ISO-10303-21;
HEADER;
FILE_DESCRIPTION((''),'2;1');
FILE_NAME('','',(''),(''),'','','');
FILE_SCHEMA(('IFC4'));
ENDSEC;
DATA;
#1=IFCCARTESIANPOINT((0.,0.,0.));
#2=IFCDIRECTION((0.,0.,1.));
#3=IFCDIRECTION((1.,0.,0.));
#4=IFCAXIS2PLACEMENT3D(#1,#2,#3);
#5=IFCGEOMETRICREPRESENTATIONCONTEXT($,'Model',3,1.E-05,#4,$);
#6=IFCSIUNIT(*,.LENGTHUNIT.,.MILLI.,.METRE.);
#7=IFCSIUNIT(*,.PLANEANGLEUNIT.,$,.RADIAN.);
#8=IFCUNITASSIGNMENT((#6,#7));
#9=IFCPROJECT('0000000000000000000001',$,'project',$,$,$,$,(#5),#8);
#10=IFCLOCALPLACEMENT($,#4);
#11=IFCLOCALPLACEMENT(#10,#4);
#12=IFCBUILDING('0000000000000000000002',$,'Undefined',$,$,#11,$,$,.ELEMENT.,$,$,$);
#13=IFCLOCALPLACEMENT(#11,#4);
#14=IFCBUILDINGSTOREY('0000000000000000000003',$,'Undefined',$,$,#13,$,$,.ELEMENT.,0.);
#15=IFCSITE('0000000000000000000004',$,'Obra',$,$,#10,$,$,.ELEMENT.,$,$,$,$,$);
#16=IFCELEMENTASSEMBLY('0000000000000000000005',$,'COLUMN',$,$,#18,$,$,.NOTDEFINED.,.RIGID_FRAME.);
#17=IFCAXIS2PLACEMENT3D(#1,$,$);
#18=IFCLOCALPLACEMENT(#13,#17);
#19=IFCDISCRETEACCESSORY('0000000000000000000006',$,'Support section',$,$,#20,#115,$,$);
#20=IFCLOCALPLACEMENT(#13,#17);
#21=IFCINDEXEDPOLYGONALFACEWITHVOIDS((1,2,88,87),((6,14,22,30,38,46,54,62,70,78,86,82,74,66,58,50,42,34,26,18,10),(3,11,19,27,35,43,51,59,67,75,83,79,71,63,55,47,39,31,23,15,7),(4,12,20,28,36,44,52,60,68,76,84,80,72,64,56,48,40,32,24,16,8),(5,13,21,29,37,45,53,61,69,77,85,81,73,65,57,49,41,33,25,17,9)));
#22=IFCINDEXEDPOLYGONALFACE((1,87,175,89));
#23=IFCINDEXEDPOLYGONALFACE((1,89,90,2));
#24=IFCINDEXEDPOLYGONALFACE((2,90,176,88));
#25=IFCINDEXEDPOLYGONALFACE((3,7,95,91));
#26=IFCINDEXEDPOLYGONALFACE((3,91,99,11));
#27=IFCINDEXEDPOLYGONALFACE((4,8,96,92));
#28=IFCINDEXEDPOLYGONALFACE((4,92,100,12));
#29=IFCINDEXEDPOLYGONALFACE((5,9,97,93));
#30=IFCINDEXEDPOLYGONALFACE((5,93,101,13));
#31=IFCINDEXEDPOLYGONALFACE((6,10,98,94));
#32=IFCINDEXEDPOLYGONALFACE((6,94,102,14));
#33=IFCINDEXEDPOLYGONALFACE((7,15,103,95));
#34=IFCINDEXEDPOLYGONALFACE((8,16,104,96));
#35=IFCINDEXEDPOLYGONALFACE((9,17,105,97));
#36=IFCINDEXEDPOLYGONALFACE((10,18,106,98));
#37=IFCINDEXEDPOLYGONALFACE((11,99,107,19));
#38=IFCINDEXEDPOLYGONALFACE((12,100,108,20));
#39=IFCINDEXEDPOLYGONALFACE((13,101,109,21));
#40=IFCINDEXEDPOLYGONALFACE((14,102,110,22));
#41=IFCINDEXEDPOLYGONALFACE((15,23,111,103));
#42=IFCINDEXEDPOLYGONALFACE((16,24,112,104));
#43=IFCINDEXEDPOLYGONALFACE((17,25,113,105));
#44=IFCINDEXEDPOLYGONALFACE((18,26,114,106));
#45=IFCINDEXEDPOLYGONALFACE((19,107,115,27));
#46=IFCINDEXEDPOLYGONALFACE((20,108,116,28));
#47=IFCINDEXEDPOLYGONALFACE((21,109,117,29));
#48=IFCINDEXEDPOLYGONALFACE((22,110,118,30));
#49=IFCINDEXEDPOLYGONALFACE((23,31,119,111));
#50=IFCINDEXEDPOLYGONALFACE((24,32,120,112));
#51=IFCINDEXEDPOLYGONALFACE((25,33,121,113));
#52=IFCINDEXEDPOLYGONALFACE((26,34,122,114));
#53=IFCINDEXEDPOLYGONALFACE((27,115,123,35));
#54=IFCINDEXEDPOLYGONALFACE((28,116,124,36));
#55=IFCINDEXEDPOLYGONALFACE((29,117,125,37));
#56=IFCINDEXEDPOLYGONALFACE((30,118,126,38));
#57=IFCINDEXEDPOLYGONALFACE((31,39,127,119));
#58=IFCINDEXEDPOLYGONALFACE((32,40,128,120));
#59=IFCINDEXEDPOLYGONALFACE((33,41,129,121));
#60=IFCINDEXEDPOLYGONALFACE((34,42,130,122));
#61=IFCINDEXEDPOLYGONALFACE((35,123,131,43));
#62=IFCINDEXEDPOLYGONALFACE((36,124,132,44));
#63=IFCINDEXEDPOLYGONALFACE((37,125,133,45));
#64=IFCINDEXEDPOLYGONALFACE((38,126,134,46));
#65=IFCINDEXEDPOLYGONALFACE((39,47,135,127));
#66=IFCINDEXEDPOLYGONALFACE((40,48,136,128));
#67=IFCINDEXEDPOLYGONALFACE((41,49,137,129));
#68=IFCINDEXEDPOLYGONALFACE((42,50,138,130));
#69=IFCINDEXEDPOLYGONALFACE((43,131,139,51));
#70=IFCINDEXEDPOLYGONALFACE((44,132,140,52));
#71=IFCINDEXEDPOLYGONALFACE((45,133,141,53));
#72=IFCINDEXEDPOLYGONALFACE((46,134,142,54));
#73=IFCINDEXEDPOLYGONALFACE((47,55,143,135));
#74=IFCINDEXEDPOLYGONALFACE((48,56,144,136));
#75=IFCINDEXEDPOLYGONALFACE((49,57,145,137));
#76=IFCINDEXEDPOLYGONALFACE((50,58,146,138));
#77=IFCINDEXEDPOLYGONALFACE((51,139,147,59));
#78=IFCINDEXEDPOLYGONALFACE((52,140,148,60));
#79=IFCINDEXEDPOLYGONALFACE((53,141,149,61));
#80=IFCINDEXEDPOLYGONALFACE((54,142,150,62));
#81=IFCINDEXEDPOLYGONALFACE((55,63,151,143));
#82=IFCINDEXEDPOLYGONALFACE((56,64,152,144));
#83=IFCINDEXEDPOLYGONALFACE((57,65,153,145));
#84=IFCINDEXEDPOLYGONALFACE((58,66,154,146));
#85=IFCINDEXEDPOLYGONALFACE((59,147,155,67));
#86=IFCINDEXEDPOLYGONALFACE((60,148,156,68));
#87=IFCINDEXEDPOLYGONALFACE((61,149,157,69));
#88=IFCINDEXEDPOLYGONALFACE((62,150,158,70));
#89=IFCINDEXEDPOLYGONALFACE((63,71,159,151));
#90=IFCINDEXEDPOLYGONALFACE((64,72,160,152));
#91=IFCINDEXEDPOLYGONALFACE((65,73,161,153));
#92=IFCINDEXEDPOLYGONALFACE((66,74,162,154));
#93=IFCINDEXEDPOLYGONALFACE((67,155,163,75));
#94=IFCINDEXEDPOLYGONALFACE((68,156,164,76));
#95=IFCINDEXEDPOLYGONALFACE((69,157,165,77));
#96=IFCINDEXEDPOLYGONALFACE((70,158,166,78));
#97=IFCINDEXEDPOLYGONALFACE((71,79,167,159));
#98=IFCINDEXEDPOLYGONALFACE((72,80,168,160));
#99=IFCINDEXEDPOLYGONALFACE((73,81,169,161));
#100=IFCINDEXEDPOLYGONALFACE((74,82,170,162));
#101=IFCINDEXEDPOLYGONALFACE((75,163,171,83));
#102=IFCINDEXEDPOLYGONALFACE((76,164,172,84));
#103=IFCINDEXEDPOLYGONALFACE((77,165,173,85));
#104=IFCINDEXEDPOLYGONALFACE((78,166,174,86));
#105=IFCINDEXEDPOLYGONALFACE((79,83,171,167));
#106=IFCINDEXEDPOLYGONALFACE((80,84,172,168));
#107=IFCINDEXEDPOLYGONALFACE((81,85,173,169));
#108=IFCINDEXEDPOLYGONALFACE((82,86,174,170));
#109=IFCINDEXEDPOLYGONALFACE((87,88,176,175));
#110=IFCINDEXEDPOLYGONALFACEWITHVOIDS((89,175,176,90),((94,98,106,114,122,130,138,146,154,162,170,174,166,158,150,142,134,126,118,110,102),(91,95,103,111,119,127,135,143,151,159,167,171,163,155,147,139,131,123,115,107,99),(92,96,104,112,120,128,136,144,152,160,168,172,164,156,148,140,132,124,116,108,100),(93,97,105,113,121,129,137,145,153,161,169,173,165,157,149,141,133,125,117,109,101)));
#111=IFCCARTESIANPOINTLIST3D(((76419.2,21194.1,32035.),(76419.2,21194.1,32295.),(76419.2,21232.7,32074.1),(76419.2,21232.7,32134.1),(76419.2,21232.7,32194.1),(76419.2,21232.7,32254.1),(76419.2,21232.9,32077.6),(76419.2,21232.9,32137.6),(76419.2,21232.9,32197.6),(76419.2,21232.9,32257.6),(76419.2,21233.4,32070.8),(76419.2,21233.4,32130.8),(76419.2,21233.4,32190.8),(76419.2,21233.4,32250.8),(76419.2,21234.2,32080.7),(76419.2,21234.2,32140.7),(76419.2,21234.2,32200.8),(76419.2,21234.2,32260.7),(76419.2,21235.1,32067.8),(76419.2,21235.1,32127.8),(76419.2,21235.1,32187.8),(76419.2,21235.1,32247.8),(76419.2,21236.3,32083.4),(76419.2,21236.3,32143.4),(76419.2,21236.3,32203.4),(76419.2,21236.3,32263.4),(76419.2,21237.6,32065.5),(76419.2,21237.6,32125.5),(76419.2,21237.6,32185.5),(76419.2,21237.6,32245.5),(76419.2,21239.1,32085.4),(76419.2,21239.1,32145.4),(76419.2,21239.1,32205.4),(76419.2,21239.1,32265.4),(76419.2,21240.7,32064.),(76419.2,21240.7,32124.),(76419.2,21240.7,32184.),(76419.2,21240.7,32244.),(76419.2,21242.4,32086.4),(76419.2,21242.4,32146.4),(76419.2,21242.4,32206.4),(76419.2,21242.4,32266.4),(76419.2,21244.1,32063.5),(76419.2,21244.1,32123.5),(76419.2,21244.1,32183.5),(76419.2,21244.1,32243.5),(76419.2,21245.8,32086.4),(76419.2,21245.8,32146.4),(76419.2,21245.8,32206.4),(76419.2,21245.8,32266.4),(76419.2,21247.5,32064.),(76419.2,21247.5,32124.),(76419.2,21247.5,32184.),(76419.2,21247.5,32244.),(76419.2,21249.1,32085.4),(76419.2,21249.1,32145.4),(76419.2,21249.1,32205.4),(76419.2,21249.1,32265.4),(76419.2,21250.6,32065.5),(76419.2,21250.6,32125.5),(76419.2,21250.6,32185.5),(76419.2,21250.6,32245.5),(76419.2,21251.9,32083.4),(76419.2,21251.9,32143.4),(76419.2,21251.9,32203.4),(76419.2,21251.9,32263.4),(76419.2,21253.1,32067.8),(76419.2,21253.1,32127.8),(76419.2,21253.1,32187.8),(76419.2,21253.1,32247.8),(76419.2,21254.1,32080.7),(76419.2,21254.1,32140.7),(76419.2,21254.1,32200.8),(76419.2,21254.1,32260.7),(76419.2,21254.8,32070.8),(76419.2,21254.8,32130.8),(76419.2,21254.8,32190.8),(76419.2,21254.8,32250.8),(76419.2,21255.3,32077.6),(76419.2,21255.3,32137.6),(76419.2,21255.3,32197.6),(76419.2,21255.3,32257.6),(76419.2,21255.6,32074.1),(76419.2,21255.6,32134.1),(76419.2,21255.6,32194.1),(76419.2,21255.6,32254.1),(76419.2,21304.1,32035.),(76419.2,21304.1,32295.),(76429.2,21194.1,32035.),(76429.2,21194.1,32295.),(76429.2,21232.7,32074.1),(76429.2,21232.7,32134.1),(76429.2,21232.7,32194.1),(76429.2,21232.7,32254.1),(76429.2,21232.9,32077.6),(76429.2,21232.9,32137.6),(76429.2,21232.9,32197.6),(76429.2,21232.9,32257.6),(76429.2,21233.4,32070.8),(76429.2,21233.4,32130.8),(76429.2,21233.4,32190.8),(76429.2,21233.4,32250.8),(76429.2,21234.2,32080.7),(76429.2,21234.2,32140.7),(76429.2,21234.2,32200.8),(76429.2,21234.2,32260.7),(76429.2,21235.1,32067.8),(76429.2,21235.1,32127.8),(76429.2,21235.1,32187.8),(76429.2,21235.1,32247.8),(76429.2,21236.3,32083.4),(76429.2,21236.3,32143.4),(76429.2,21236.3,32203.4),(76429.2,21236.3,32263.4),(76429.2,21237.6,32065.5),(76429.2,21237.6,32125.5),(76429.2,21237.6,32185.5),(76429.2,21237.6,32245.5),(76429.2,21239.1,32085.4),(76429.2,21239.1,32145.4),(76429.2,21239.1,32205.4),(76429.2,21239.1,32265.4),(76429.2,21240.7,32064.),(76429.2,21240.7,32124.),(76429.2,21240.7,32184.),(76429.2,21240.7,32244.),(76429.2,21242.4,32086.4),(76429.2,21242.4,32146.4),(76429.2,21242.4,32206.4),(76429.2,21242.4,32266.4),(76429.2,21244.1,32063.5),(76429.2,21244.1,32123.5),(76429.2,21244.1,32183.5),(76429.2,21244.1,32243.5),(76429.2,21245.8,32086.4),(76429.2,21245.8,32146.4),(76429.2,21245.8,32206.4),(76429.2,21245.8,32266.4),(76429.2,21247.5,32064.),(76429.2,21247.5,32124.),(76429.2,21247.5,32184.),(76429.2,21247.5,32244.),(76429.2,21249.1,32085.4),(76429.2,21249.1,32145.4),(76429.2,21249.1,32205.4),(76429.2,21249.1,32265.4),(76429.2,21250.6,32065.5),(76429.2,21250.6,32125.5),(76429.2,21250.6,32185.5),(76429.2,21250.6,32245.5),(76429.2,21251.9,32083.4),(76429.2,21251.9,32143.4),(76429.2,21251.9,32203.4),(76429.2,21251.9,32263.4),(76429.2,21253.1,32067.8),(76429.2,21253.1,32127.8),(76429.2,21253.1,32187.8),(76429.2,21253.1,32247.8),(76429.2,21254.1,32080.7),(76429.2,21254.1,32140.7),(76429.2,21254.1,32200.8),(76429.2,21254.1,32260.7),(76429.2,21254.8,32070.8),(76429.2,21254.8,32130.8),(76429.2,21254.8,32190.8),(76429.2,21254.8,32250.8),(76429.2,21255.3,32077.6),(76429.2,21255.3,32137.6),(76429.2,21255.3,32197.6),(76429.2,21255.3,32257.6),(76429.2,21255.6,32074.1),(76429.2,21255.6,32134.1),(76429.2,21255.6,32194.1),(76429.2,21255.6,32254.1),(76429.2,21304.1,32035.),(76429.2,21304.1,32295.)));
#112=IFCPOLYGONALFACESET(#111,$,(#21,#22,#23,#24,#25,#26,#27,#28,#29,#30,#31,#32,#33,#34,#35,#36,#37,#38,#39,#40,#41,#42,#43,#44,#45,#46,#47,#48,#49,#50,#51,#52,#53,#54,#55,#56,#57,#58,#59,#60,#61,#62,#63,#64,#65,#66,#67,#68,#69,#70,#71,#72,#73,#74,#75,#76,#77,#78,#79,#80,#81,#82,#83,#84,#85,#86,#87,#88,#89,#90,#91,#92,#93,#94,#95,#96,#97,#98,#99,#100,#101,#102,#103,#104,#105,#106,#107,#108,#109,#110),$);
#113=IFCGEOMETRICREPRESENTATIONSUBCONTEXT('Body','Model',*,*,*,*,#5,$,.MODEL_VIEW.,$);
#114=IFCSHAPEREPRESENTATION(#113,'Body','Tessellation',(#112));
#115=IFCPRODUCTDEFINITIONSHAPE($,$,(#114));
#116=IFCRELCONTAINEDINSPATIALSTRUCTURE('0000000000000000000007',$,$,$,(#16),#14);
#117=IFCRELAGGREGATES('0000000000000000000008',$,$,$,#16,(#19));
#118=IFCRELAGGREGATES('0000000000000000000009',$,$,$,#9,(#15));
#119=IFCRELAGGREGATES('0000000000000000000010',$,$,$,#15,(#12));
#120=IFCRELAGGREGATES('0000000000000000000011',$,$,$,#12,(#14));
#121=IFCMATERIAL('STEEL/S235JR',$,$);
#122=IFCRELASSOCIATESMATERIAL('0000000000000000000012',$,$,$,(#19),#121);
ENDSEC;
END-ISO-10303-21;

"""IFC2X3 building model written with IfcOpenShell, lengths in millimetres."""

from ifc_helpers import new_model, si_unit, frame, origin_with_axes, origin_2d_with_axis, place, context, subcontext, project, spatial, rectangle, circle, extrude, source, transform, mapped, material, element, aggregate, save


model = new_model("IFC2X3")

# Units and contexts
model_context = context("Model", 3, precision=1e-05, world=origin_with_axes())
body_context = subcontext(model_context, "Body", "Model", "MODEL_VIEW")
ifc_project = project(units=[si_unit("LENGTHUNIT", "METRE", prefix="MILLI"), si_unit("PLANEANGLEUNIT", "RADIAN")], contexts=[model_context])

# Site, building, storey
site_placement = place(None, origin_with_axes())
site = spatial("IfcSite", under=ifc_project, at=site_placement, Name="Obra", CompositionType="ELEMENT")
building_placement = place(site_placement, origin_with_axes())
building = spatial("IfcBuilding", under=site, at=building_placement, Name="Undefined", CompositionType="ELEMENT")
storey_placement = place(building_placement, origin_with_axes())
storey = spatial("IfcBuildingStorey", under=building, at=storey_placement, Name="Undefined", CompositionType="ELEMENT", Elevation=0.0)

# Shared definitions
ifc_material_1 = material(Name="STEEL/S235JR")

# Element assembly, discrete accessory, opening
assembly_1_placement = place(storey_placement, origin_with_axes())
assembly_1 = element("IfcElementAssembly", 1, at=assembly_1_placement, inside=storey, Name="COLUMN", AssemblyPlace="NOTDEFINED", PredefinedType="RIGID_FRAME")
discrete_accessory_1_placement = place(assembly_1_placement, frame((76424.2, 21249.1, 32035.0), z_axis=(0.0, 0.0, 1.0), x_axis=(0.0, 1.0, 0.0)))
discrete_accessory_1 = element("IfcDiscreteAccessory", 2, at=discrete_accessory_1_placement, material=ifc_material_1, Name="Support section", context=body_context, shape_type="SweptSolid", body=[
    extrude(rectangle(XDim=10.0, YDim=110.0, at=origin_2d_with_axis()), frame((0.0, 0.0, 260.0), z_axis=(0.0, 0.0, -1.0), x_axis=(0.0, 1.0, 0.0)), (0.0, 0.0, 1.0), 260.0),
])
shared_shape_1 = source(origin_with_axes(), body_context, "Body", "SweptSolid", [
    extrude(circle(Radius=11.5, at=origin_2d_with_axis()), frame((0.0, -13.4, 0.0), z_axis=(0.0, 1.0, 0.0), x_axis=(1.0, 0.0, 0.0)), (0.0, 0.0, 1.0), 10.2),
])
opening_1_placement = place(assembly_1_placement, frame((76432.5, 21294.1, 32300.0), z_axis=(0.0, -1.0, 0.0), x_axis=(0.0, 0.0, -1.0)))
element("IfcOpeningElement", 3, at=opening_1_placement, cuts=discrete_accessory_1, ObjectType="Opening", context=body_context, shape_type="MappedRepresentation", body=[
    mapped(shared_shape_1, transform((45.0, 0.0, 50.0))),
    mapped(shared_shape_1, transform((105.0, 0.0, 50.0))),
    mapped(shared_shape_1, transform((165.0, 0.0, 50.0))),
    mapped(shared_shape_1, transform((225.0, 0.0, 50.0))),
])
aggregate(assembly_1, [discrete_accessory_1])

save(model, "model.ifc")
